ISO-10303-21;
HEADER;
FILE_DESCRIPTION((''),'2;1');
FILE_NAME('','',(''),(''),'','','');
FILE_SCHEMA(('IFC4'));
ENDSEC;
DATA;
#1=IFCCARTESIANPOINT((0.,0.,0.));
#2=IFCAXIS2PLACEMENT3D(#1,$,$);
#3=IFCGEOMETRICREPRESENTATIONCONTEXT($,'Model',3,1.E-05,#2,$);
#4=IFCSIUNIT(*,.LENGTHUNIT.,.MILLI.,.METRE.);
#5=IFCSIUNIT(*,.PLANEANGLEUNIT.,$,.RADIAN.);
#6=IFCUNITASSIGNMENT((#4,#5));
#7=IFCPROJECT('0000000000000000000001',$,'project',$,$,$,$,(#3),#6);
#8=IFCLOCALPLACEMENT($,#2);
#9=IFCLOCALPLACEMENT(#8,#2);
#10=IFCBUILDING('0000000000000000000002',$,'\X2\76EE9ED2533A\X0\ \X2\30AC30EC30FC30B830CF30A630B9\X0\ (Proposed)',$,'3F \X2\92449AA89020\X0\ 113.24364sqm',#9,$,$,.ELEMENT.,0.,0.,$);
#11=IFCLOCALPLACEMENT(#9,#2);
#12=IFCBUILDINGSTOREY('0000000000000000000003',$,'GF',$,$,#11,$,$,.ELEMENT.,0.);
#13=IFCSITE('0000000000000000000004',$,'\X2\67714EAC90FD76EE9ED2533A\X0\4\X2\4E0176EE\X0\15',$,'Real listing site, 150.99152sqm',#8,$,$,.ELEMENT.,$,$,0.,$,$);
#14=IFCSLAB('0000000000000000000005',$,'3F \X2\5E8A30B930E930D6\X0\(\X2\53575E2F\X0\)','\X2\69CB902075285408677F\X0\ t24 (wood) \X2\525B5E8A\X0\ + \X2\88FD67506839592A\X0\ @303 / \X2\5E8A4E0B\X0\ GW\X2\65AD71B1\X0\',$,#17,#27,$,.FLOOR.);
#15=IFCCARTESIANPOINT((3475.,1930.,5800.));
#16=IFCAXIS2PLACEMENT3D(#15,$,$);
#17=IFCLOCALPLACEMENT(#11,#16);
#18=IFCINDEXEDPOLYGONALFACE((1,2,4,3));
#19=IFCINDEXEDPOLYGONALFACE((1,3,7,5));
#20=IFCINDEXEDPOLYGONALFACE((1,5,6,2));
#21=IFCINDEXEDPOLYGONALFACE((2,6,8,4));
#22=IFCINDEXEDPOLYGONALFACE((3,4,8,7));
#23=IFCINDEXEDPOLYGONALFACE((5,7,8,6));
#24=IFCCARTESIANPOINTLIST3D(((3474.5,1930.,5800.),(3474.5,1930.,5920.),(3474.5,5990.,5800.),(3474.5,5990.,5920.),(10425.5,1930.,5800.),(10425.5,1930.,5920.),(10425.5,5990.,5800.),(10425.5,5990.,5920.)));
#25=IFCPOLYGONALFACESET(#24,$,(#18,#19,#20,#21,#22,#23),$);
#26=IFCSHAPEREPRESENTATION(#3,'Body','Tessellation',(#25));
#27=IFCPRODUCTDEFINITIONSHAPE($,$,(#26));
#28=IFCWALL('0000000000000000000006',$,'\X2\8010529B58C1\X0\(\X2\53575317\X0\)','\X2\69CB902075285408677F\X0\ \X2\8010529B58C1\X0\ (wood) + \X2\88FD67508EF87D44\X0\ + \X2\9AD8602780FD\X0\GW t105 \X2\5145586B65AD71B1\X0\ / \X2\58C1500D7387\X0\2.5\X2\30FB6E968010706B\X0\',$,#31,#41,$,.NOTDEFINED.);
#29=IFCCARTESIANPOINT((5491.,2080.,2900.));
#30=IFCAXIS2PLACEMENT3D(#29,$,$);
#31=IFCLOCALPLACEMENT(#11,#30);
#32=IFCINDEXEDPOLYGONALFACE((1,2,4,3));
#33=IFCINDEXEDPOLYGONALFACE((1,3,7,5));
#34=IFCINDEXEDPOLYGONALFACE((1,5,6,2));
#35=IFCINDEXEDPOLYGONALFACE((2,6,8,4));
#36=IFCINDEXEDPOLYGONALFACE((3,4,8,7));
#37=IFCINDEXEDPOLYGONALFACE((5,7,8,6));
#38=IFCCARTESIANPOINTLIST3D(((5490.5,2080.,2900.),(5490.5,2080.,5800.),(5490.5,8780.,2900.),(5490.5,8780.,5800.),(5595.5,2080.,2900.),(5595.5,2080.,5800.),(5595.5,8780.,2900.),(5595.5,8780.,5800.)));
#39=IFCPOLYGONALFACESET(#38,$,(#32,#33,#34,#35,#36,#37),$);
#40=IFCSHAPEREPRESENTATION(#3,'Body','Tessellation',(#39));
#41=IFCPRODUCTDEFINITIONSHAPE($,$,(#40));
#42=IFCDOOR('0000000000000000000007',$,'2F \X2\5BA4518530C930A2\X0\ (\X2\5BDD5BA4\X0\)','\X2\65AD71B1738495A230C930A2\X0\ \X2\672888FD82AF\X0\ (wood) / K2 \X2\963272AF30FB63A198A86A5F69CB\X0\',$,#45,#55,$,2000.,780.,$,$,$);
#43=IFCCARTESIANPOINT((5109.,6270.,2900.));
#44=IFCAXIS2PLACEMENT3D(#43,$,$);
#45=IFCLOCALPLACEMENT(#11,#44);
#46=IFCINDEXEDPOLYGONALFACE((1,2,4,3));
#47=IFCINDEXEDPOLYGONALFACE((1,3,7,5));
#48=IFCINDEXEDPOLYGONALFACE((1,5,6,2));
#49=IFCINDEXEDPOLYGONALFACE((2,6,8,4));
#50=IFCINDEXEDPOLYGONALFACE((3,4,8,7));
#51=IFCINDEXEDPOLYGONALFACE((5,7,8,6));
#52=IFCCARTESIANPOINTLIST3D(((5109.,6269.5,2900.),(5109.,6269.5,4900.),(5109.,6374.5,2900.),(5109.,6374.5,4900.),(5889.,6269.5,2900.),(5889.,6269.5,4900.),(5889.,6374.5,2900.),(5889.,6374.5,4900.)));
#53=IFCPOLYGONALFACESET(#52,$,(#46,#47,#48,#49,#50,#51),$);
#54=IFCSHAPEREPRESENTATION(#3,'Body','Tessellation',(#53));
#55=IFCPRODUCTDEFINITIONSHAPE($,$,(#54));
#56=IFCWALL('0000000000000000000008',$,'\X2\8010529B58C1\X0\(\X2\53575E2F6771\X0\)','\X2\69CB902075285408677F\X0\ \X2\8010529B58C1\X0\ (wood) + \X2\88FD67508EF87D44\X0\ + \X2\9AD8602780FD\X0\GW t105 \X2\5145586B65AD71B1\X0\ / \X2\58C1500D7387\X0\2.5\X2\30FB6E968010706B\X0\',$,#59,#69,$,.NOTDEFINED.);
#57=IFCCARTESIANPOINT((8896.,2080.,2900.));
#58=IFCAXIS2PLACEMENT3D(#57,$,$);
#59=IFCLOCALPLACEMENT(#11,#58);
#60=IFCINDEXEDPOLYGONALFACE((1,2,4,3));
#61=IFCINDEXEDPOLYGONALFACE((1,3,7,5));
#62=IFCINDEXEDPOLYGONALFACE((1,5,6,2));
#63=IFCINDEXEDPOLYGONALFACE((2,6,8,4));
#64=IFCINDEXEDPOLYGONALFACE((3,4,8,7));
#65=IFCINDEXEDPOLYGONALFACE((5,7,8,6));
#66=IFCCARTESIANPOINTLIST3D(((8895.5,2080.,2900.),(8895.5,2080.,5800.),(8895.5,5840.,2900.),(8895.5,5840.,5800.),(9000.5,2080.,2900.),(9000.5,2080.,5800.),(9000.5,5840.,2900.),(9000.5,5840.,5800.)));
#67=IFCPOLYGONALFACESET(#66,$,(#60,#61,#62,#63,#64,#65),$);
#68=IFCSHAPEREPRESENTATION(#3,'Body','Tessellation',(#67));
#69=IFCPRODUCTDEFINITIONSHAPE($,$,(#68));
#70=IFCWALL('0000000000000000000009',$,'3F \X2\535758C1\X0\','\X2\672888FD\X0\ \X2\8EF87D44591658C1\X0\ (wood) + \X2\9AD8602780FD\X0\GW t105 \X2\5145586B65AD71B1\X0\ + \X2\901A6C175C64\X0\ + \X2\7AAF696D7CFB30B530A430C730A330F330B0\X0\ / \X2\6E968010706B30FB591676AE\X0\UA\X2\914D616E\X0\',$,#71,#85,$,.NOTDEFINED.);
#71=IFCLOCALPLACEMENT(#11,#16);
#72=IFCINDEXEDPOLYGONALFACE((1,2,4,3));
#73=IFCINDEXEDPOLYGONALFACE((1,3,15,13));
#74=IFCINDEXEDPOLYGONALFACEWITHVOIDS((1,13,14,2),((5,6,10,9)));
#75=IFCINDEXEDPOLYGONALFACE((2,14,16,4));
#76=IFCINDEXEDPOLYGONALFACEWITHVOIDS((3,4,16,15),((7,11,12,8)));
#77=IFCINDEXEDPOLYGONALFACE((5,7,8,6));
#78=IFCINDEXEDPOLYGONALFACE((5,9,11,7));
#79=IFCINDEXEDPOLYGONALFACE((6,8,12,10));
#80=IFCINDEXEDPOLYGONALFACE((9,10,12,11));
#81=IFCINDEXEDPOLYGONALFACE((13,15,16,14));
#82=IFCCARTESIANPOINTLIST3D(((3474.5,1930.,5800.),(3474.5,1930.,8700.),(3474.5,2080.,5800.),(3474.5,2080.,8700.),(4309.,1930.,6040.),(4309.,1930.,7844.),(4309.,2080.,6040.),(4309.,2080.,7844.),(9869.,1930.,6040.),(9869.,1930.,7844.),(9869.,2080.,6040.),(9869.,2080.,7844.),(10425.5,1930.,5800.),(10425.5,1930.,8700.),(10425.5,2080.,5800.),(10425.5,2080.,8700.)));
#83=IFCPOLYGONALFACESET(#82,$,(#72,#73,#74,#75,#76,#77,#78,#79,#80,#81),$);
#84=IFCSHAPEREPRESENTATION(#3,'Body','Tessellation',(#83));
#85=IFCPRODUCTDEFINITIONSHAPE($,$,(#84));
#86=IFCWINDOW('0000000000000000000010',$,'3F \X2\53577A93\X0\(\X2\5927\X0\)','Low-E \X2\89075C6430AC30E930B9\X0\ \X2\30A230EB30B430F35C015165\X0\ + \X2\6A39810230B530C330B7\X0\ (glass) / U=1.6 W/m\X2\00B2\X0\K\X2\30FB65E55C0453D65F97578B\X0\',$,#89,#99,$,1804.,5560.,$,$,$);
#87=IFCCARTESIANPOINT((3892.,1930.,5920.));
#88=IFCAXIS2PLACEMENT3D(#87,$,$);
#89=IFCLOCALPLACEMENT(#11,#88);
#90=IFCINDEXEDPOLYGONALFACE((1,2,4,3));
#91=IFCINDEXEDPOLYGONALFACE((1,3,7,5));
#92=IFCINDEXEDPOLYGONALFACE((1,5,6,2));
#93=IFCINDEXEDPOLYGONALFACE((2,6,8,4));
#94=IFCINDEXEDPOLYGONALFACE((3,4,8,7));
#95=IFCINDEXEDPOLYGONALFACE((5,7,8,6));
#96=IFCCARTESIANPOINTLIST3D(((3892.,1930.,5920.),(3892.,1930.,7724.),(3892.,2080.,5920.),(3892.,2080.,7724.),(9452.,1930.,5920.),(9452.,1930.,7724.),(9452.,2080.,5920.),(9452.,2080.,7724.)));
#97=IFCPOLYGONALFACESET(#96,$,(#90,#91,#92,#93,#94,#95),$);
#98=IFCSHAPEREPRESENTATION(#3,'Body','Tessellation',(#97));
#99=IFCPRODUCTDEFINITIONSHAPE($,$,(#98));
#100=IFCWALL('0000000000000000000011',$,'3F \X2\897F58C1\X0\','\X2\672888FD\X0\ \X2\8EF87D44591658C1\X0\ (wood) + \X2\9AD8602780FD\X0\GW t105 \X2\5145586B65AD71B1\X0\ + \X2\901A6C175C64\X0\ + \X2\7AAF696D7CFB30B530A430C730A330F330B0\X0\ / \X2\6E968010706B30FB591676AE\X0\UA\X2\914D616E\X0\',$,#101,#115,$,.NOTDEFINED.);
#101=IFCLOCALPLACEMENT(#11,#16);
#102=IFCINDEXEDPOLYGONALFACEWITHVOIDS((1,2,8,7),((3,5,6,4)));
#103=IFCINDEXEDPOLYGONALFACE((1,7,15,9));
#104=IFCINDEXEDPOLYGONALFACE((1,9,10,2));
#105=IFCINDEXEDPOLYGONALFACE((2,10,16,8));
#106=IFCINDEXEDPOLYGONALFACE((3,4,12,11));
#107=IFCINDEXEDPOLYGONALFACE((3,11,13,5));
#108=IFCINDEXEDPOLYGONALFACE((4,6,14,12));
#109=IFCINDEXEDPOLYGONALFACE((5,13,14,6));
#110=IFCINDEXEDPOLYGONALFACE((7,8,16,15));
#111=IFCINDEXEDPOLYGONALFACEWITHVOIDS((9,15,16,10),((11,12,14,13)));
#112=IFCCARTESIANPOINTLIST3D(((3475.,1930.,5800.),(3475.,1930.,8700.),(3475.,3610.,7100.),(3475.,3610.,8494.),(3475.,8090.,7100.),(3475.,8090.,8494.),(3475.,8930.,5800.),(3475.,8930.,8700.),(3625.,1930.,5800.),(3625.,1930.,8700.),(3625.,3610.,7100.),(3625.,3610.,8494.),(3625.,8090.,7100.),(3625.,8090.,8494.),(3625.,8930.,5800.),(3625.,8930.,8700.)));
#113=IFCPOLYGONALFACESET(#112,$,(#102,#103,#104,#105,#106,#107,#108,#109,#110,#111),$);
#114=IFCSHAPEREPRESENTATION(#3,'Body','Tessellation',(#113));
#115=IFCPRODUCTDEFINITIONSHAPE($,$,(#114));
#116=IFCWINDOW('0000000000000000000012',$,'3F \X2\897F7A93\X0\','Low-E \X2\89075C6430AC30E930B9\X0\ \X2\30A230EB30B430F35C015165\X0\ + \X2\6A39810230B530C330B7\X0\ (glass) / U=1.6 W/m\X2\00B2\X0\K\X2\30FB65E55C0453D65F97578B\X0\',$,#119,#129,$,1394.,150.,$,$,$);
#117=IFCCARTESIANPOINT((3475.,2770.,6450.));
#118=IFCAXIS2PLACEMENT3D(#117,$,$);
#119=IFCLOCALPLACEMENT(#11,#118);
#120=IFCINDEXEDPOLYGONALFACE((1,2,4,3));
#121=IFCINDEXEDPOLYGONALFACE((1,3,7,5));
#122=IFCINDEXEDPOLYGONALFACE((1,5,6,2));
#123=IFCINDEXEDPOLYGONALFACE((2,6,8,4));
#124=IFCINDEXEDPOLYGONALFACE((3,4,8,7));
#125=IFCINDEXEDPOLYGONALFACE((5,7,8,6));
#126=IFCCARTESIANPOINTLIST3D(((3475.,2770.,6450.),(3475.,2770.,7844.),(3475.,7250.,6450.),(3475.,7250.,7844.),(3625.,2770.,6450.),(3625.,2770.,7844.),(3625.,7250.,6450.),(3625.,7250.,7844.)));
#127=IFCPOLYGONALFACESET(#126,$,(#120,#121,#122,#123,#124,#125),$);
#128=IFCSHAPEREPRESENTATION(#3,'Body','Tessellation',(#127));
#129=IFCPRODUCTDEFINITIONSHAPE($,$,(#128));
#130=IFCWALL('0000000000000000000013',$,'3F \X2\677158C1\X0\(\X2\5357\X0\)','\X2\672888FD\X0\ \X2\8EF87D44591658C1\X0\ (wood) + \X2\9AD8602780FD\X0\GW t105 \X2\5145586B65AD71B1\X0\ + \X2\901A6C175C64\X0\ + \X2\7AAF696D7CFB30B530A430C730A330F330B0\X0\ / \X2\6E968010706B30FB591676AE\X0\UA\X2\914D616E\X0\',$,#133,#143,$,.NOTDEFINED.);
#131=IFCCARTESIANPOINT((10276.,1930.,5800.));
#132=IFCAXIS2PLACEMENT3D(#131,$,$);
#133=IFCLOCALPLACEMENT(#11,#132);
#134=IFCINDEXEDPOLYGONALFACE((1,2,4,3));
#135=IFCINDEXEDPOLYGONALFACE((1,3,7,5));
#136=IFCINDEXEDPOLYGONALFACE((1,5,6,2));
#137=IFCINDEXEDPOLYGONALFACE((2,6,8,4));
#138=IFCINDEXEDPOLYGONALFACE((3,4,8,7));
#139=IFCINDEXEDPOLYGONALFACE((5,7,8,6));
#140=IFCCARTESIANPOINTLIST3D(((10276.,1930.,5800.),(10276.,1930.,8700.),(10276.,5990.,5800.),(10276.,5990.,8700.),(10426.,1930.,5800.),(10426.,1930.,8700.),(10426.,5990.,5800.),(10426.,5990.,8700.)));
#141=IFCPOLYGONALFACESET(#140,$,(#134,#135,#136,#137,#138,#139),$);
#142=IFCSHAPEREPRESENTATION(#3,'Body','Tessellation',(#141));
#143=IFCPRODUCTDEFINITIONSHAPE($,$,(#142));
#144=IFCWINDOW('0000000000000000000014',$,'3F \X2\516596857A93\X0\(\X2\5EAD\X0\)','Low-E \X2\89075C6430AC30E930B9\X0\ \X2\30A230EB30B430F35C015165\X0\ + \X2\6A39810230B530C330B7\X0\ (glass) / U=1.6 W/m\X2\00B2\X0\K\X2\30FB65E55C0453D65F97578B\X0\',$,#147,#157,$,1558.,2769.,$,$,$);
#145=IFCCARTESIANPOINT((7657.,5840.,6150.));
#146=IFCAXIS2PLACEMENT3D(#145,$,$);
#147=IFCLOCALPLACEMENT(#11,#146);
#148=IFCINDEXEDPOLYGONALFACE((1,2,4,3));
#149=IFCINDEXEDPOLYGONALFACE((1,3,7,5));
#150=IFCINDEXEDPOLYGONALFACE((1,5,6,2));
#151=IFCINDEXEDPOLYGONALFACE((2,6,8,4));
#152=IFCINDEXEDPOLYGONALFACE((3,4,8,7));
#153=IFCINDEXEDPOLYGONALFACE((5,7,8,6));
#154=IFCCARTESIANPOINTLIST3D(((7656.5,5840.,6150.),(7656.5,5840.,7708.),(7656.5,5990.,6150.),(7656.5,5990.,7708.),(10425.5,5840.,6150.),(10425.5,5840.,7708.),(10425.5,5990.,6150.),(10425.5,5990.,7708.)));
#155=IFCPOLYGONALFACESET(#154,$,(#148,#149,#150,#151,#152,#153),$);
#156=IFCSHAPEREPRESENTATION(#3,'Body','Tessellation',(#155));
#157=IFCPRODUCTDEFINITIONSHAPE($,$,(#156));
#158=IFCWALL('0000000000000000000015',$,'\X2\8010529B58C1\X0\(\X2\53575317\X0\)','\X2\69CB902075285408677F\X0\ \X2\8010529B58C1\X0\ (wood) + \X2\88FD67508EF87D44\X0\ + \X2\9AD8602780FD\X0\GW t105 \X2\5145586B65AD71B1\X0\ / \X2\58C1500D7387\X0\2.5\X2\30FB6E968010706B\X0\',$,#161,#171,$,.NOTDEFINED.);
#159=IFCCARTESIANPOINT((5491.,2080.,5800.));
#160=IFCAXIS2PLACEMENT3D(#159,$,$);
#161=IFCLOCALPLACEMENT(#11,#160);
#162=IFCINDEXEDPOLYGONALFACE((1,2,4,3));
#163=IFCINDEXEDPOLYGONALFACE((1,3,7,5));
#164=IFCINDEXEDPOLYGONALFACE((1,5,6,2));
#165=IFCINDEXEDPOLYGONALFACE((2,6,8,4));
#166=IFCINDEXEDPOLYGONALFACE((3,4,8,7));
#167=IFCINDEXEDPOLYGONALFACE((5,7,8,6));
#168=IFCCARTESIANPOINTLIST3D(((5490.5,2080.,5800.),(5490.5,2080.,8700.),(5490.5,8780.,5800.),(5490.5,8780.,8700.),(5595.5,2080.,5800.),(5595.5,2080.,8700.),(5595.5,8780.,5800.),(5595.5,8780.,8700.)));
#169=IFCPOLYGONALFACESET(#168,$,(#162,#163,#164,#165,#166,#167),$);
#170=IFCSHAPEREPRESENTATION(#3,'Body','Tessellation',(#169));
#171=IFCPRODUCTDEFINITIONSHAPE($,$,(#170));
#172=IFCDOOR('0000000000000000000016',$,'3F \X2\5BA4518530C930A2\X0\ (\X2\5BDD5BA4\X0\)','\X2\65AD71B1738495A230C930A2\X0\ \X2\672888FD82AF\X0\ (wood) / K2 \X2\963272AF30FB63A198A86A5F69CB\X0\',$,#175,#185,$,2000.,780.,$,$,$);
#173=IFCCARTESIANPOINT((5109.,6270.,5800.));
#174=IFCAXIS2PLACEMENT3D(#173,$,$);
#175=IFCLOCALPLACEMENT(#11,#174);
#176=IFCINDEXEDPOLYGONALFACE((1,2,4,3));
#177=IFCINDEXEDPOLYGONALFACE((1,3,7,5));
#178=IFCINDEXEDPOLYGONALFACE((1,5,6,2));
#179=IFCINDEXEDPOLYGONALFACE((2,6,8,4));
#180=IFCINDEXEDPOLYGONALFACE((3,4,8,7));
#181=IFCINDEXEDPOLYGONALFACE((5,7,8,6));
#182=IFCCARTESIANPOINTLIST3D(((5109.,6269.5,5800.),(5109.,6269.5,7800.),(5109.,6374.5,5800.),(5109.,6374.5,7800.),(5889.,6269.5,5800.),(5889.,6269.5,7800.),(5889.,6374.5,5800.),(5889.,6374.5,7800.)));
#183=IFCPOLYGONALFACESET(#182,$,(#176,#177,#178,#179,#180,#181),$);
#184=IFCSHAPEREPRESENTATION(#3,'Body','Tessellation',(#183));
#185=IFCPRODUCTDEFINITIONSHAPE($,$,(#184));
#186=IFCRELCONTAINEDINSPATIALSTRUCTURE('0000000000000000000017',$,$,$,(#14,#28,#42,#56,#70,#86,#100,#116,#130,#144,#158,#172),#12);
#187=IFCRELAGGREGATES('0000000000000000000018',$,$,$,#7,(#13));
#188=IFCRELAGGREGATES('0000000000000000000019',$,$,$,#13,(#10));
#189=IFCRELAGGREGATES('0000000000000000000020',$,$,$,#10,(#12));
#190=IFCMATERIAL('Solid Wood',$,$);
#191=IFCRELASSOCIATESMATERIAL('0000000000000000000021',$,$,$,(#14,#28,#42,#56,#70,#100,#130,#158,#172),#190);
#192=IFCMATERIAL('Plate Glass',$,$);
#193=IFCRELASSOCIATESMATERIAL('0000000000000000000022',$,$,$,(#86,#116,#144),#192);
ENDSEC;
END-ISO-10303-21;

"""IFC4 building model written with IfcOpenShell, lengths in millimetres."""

from ifc_helpers import new_model, si_unit, frame, frame_2d, origin, place, context, project, spatial, rectangle, extrude, material, element, fill, save


model = new_model("IFC4")

# Units and contexts
model_context = context("Model", 3, precision=1e-05, world=origin())
ifc_project = project(units=[si_unit("LENGTHUNIT", "METRE", prefix="MILLI"), si_unit("PLANEANGLEUNIT", "RADIAN")], contexts=[model_context])

# Site, building, storey
site_placement = place(None, origin())
site = spatial("IfcSite", under=ifc_project, at=site_placement, Name="東京都目黒区4丁目15", ObjectType="Real listing site, 150.99152sqm", CompositionType="ELEMENT", RefElevation=0.0)
building_placement = place(site_placement, origin())
building = spatial("IfcBuilding", under=site, at=building_placement, Name="目黒区 ガレージハウス (Proposed)", ObjectType="3F 鉄骨造 113.24364sqm", CompositionType="ELEMENT", ElevationOfRefHeight=0.0, ElevationOfTerrain=0.0)
storey_placement = place(building_placement, origin())
storey = spatial("IfcBuildingStorey", under=building, at=storey_placement, Name="GF", CompositionType="ELEMENT", Elevation=0.0)

# Slab
ifc_material_1 = material(Name="Solid Wood")
slab_placement = place(storey_placement, frame((3475.0, 1930.0, 5800.0)))
element("IfcSlab", 1, at=slab_placement, inside=storey, material=ifc_material_1, Name="3F 床スラブ(南帯)", Description="構造用合板 t24 (wood) 剛床 + 製材根太 @303 / 床下 GW断熱", PredefinedType="FLOOR", context=model_context, shape_type="SweptSolid", body=[
    extrude(rectangle(XDim=6951.0, YDim=4060.0, at=frame_2d((3475.0, 2030.0))), frame((3475.0, 1930.0, 5800.0)), (0.0, 0.0, 1.0), 120.0),
])

# Wall, opening, door
wall_1_placement = place(storey_placement, frame((5491.0, 2080.0, 2900.0)))
wall_1 = element("IfcWall", 2, at=wall_1_placement, inside=storey, material=ifc_material_1, Name="耐力壁(南北)", Description="構造用合板 耐力壁 (wood) + 製材軸組 + 高性能GW t105 充填断熱 / 壁倍率2.5・準耐火", PredefinedType="NOTDEFINED", context=model_context, shape_type="SweptSolid", body=[
    extrude(rectangle(XDim=105.0, YDim=6700.0, at=frame_2d((52.0, 3350.0))), frame((5491.0, 2080.0, 2900.0)), (0.0, 0.0, 1.0), 2900.0),
])
opening_1_placement = place(storey_placement, frame((5109.0, 6270.0, 2900.0)))
opening_1 = element("IfcOpeningElement", 3, at=opening_1_placement, cuts=wall_1, PredefinedType="NOTDEFINED", context=model_context, shape_type="SweptSolid", body=[
    extrude(rectangle(XDim=780.0, YDim=105.0, at=frame_2d((390.0, 52.0))), frame((5109.0, 6270.0, 2900.0)), (0.0, 0.0, 1.0), 2000.0),
])
door_1_placement = place(storey_placement, frame((5109.0, 6270.0, 2900.0)))
door_1 = element("IfcDoor", 4, at=door_1_placement, inside=storey, material=ifc_material_1, Name="2F 室内ドア (寝室)", Description="断熱玄関ドア 木製芯 (wood) / K2 防犯・採風機構", OverallHeight=2000.0, OverallWidth=780.0, context=model_context, shape_type="SweptSolid", body=[
    extrude(rectangle(XDim=780.0, YDim=105.0, at=frame_2d((390.0, 52.0))), frame((5109.0, 6270.0, 2900.0)), (0.0, 0.0, 1.0), 2000.0),
])
fill(opening_1, door_1)

# Wall
wall_2_placement = place(storey_placement, frame((8896.0, 2080.0, 2900.0)))
element("IfcWall", 5, at=wall_2_placement, inside=storey, material=ifc_material_1, Name="耐力壁(南帯東)", Description="構造用合板 耐力壁 (wood) + 製材軸組 + 高性能GW t105 充填断熱 / 壁倍率2.5・準耐火", PredefinedType="NOTDEFINED", context=model_context, shape_type="SweptSolid", body=[
    extrude(rectangle(XDim=105.0, YDim=3760.0, at=frame_2d((52.0, 1880.0))), frame((8896.0, 2080.0, 2900.0)), (0.0, 0.0, 1.0), 2900.0),
])

# Walls, openings, windows
wall_3_placement = place(storey_placement, frame((3475.0, 1930.0, 5800.0)))
wall_3 = element("IfcWall", 6, at=wall_3_placement, inside=storey, material=ifc_material_1, Name="3F 南壁", Description="木製 軸組外壁 (wood) + 高性能GW t105 充填断熱 + 通気層 + 窯業系サイディング / 準耐火・外皮UA配慮", PredefinedType="NOTDEFINED", context=model_context, shape_type="SweptSolid", body=[
    extrude(rectangle(XDim=6951.0, YDim=150.0, at=frame_2d((3475.0, 75.0))), frame((3475.0, 1930.0, 5800.0)), (0.0, 0.0, 1.0), 2900.0),
])
opening_2_placement = place(storey_placement, frame((3892.0, 1930.0, 5920.0)))
opening_2 = element("IfcOpeningElement", 7, at=opening_2_placement, cuts=wall_3, PredefinedType="NOTDEFINED", context=model_context, shape_type="SweptSolid", body=[
    extrude(rectangle(XDim=5560.0, YDim=150.0, at=frame_2d((2780.0, 75.0))), frame((3892.0, 1930.0, 5920.0)), (0.0, 0.0, 1.0), 1804.0),
])
ifc_material_2 = material(Name="Plate Glass")
window_1_placement = place(storey_placement, frame((3892.0, 1930.0, 5920.0)))
window_1 = element("IfcWindow", 8, at=window_1_placement, inside=storey, material=ifc_material_2, Name="3F 南窓(大)", Description="Low-E 複層ガラス アルゴン封入 + 樹脂サッシ (glass) / U=1.6 W/m²K・日射取得型", OverallHeight=1804.0, OverallWidth=5560.0, context=model_context, shape_type="SweptSolid", body=[
    extrude(rectangle(XDim=5560.0, YDim=150.0, at=frame_2d((2780.0, 75.0))), frame((3892.0, 1930.0, 5920.0)), (0.0, 0.0, 1.0), 1804.0),
])
fill(opening_2, window_1)
wall_4_placement = place(storey_placement, frame((3475.0, 1930.0, 5800.0)))
wall_4 = element("IfcWall", 9, at=wall_4_placement, inside=storey, material=ifc_material_1, Name="3F 西壁", Description="木製 軸組外壁 (wood) + 高性能GW t105 充填断熱 + 通気層 + 窯業系サイディング / 準耐火・外皮UA配慮", PredefinedType="NOTDEFINED", context=model_context, shape_type="SweptSolid", body=[
    extrude(rectangle(XDim=150.0, YDim=7000.0, at=frame_2d((75.0, 3500.0))), frame((3475.0, 1930.0, 5800.0)), (0.0, 0.0, 1.0), 2900.0),
])
opening_3_placement = place(storey_placement, frame((3475.0, 2770.0, 6450.0)))
opening_3 = element("IfcOpeningElement", 10, at=opening_3_placement, cuts=wall_4, PredefinedType="NOTDEFINED", context=model_context, shape_type="SweptSolid", body=[
    extrude(rectangle(XDim=150.0, YDim=4480.0, at=frame_2d((75.0, 2240.0))), frame((3475.0, 2770.0, 6450.0)), (0.0, 0.0, 1.0), 1394.0),
])
window_2_placement = place(storey_placement, frame((3475.0, 2770.0, 6450.0)))
window_2 = element("IfcWindow", 11, at=window_2_placement, inside=storey, material=ifc_material_2, Name="3F 西窓", Description="Low-E 複層ガラス アルゴン封入 + 樹脂サッシ (glass) / U=1.6 W/m²K・日射取得型", OverallHeight=1394.0, OverallWidth=150.0, context=model_context, shape_type="SweptSolid", body=[
    extrude(rectangle(XDim=150.0, YDim=4480.0, at=frame_2d((75.0, 2240.0))), frame((3475.0, 2770.0, 6450.0)), (0.0, 0.0, 1.0), 1394.0),
])
fill(opening_3, window_2)
wall_5_placement = place(storey_placement, frame((10276.0, 1930.0, 5800.0)))
wall_5 = element("IfcWall", 12, at=wall_5_placement, inside=storey, material=ifc_material_1, Name="3F 東壁(南)", Description="木製 軸組外壁 (wood) + 高性能GW t105 充填断熱 + 通気層 + 窯業系サイディング / 準耐火・外皮UA配慮", PredefinedType="NOTDEFINED", context=model_context, shape_type="SweptSolid", body=[
    extrude(rectangle(XDim=150.0, YDim=4060.0, at=frame_2d((75.0, 2030.0))), frame((10276.0, 1930.0, 5800.0)), (0.0, 0.0, 1.0), 2900.0),
])
opening_4_placement = place(storey_placement, frame((7657.0, 5840.0, 6150.0)))
opening_4 = element("IfcOpeningElement", 13, at=opening_4_placement, cuts=wall_5, PredefinedType="NOTDEFINED", context=model_context, shape_type="SweptSolid", body=[
    extrude(rectangle(XDim=2769.0, YDim=150.0, at=frame_2d((1384.0, 75.0))), frame((7657.0, 5840.0, 6150.0)), (0.0, 0.0, 1.0), 1558.0),
])
window_3_placement = place(storey_placement, frame((7657.0, 5840.0, 6150.0)))
window_3 = element("IfcWindow", 14, at=window_3_placement, inside=storey, material=ifc_material_2, Name="3F 入隅窓(庭)", Description="Low-E 複層ガラス アルゴン封入 + 樹脂サッシ (glass) / U=1.6 W/m²K・日射取得型", OverallHeight=1558.0, OverallWidth=2769.0, context=model_context, shape_type="SweptSolid", body=[
    extrude(rectangle(XDim=2769.0, YDim=150.0, at=frame_2d((1384.0, 75.0))), frame((7657.0, 5840.0, 6150.0)), (0.0, 0.0, 1.0), 1558.0),
])
fill(opening_4, window_3)

# Wall, opening, door
wall_6_placement = place(storey_placement, frame((5491.0, 2080.0, 5800.0)))
wall_6 = element("IfcWall", 15, at=wall_6_placement, inside=storey, material=ifc_material_1, Name="耐力壁(南北)", Description="構造用合板 耐力壁 (wood) + 製材軸組 + 高性能GW t105 充填断熱 / 壁倍率2.5・準耐火", PredefinedType="NOTDEFINED", context=model_context, shape_type="SweptSolid", body=[
    extrude(rectangle(XDim=105.0, YDim=6700.0, at=frame_2d((52.0, 3350.0))), frame((5491.0, 2080.0, 5800.0)), (0.0, 0.0, 1.0), 2900.0),
])
opening_5_placement = place(storey_placement, frame((5109.0, 6270.0, 5800.0)))
opening_5 = element("IfcOpeningElement", 16, at=opening_5_placement, cuts=wall_6, PredefinedType="NOTDEFINED", context=model_context, shape_type="SweptSolid", body=[
    extrude(rectangle(XDim=780.0, YDim=105.0, at=frame_2d((390.0, 52.0))), frame((5109.0, 6270.0, 5800.0)), (0.0, 0.0, 1.0), 2000.0),
])
door_2_placement = place(storey_placement, frame((5109.0, 6270.0, 5800.0)))
door_2 = element("IfcDoor", 17, at=door_2_placement, inside=storey, material=ifc_material_1, Name="3F 室内ドア (寝室)", Description="断熱玄関ドア 木製芯 (wood) / K2 防犯・採風機構", OverallHeight=2000.0, OverallWidth=780.0, context=model_context, shape_type="SweptSolid", body=[
    extrude(rectangle(XDim=780.0, YDim=105.0, at=frame_2d((390.0, 52.0))), frame((5109.0, 6270.0, 5800.0)), (0.0, 0.0, 1.0), 2000.0),
])
fill(opening_5, door_2)

save(model, "model.ifc")
